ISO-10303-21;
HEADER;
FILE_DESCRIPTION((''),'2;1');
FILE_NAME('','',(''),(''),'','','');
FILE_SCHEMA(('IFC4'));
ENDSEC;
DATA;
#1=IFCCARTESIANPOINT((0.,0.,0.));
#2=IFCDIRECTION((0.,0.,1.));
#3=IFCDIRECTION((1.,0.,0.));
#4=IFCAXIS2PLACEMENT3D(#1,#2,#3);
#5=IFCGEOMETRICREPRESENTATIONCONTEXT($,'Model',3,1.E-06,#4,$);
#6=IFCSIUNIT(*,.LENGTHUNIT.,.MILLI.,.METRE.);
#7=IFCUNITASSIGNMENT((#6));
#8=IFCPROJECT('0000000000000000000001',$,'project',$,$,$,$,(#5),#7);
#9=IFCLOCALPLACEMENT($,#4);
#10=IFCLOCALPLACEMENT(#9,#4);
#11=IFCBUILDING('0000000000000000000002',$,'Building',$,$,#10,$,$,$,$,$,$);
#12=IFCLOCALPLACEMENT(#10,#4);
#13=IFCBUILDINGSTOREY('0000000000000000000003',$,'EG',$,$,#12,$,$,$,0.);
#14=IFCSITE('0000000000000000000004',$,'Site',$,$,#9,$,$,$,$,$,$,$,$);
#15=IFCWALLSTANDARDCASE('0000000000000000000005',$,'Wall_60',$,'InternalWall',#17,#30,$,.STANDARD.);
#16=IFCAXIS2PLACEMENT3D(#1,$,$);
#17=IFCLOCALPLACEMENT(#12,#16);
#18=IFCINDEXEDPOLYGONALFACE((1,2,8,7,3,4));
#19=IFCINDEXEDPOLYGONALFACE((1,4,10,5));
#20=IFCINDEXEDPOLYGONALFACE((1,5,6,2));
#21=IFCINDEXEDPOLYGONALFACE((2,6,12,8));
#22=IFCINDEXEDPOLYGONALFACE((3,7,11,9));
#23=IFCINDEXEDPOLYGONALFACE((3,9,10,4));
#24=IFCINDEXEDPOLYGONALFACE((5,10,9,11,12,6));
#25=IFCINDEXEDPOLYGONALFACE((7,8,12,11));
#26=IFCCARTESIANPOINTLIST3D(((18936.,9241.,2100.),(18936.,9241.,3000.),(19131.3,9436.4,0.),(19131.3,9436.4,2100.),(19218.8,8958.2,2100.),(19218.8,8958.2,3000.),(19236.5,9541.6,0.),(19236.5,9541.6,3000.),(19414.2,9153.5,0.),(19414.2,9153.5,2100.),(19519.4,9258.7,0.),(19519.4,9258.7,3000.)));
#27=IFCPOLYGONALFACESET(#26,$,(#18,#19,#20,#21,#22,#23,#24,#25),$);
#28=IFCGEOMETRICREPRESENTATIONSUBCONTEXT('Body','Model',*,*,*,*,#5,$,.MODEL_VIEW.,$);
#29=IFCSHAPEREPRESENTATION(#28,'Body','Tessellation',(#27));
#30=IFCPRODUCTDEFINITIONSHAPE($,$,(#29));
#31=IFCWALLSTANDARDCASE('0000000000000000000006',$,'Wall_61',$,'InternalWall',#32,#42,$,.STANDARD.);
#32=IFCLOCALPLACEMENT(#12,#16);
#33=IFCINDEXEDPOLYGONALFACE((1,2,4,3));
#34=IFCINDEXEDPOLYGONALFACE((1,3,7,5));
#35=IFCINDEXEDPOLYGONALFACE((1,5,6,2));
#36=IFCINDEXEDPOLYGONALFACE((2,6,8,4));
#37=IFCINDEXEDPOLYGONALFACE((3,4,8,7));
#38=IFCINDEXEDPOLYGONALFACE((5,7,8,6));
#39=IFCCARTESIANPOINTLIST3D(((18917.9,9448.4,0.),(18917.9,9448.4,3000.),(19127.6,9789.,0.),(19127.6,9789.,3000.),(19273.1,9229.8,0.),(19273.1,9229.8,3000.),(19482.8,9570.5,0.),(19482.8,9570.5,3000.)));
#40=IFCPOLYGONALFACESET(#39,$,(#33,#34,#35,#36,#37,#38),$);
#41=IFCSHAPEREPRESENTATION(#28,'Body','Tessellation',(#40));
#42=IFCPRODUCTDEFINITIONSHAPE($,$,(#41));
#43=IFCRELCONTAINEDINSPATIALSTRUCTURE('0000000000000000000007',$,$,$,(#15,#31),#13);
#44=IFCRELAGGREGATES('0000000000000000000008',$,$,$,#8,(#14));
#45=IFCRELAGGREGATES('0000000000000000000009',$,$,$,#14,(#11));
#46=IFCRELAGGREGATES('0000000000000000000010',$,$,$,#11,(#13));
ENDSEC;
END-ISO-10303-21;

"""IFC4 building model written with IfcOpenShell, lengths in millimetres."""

from ifc_helpers import new_model, si_unit, frame, origin_with_axes, place, context, subcontext, project, spatial, rectangle, extrude, element, save


model = new_model("IFC4")

# Units and contexts
model_context = context("Model", 3, precision=1e-06, world=origin_with_axes())
body_context = subcontext(model_context, "Body", "Model", "MODEL_VIEW")
ifc_project = project(units=[si_unit("LENGTHUNIT", "METRE", prefix="MILLI")], contexts=[model_context])

# Site, building, storey
site_placement = place(None, origin_with_axes())
site = spatial("IfcSite", under=ifc_project, at=site_placement, Name="Site")
building_placement = place(site_placement, origin_with_axes())
building = spatial("IfcBuilding", under=site, at=building_placement, Name="Building")
storey_placement = place(building_placement, origin_with_axes())
storey = spatial("IfcBuildingStorey", under=building, at=storey_placement, Name="EG", Elevation=0.0)

# Wall, opening
wall_1_placement = place(storey_placement, origin_with_axes())
wall_1 = element("IfcWallStandardCase", 1, at=wall_1_placement, inside=storey, Name="Wall_60", ObjectType="InternalWall", PredefinedType="STANDARD", context=body_context, shape_type="SweptSolid", body=[
    extrude(rectangle(XDim=425.0, YDim=400.0), frame((19227.7, 9249.9, 0.0), z_axis=(0.0, 0.0, 1.0), x_axis=(-0.707107, -0.707107, 0.0)), (0.0, 0.0, 1.0), 3000.0),
])
opening_1_placement = place(wall_1_placement, origin_with_axes())
element("IfcOpeningElement", 2, at=opening_1_placement, inside=storey, cuts=wall_1, context=body_context, shape_type="SweptSolid", body=[
    extrude(rectangle(XDim=1031.2, YDim=400.0), frame((18908.2, 8930.4, 0.0), z_axis=(0.0, 0.0, 1.0), x_axis=(-0.707107, -0.707107, 0.0)), (0.0, 0.0, 1.0), 2100.0),
])

# Wall
wall_2_placement = place(storey_placement, origin_with_axes())
element("IfcWallStandardCase", 3, at=wall_2_placement, inside=storey, Name="Wall_61", ObjectType="InternalWall", PredefinedType="STANDARD", context=body_context, shape_type="SweptSolid", body=[
    extrude(rectangle(XDim=417.1, YDim=400.0), frame((19200.3, 9509.4, 0.0), z_axis=(0.0, 0.0, 1.0), x_axis=(-0.851658, 0.524097, 0.0)), (0.0, 0.0, 1.0), 3000.0),
])

save(model, "model.ifc")
